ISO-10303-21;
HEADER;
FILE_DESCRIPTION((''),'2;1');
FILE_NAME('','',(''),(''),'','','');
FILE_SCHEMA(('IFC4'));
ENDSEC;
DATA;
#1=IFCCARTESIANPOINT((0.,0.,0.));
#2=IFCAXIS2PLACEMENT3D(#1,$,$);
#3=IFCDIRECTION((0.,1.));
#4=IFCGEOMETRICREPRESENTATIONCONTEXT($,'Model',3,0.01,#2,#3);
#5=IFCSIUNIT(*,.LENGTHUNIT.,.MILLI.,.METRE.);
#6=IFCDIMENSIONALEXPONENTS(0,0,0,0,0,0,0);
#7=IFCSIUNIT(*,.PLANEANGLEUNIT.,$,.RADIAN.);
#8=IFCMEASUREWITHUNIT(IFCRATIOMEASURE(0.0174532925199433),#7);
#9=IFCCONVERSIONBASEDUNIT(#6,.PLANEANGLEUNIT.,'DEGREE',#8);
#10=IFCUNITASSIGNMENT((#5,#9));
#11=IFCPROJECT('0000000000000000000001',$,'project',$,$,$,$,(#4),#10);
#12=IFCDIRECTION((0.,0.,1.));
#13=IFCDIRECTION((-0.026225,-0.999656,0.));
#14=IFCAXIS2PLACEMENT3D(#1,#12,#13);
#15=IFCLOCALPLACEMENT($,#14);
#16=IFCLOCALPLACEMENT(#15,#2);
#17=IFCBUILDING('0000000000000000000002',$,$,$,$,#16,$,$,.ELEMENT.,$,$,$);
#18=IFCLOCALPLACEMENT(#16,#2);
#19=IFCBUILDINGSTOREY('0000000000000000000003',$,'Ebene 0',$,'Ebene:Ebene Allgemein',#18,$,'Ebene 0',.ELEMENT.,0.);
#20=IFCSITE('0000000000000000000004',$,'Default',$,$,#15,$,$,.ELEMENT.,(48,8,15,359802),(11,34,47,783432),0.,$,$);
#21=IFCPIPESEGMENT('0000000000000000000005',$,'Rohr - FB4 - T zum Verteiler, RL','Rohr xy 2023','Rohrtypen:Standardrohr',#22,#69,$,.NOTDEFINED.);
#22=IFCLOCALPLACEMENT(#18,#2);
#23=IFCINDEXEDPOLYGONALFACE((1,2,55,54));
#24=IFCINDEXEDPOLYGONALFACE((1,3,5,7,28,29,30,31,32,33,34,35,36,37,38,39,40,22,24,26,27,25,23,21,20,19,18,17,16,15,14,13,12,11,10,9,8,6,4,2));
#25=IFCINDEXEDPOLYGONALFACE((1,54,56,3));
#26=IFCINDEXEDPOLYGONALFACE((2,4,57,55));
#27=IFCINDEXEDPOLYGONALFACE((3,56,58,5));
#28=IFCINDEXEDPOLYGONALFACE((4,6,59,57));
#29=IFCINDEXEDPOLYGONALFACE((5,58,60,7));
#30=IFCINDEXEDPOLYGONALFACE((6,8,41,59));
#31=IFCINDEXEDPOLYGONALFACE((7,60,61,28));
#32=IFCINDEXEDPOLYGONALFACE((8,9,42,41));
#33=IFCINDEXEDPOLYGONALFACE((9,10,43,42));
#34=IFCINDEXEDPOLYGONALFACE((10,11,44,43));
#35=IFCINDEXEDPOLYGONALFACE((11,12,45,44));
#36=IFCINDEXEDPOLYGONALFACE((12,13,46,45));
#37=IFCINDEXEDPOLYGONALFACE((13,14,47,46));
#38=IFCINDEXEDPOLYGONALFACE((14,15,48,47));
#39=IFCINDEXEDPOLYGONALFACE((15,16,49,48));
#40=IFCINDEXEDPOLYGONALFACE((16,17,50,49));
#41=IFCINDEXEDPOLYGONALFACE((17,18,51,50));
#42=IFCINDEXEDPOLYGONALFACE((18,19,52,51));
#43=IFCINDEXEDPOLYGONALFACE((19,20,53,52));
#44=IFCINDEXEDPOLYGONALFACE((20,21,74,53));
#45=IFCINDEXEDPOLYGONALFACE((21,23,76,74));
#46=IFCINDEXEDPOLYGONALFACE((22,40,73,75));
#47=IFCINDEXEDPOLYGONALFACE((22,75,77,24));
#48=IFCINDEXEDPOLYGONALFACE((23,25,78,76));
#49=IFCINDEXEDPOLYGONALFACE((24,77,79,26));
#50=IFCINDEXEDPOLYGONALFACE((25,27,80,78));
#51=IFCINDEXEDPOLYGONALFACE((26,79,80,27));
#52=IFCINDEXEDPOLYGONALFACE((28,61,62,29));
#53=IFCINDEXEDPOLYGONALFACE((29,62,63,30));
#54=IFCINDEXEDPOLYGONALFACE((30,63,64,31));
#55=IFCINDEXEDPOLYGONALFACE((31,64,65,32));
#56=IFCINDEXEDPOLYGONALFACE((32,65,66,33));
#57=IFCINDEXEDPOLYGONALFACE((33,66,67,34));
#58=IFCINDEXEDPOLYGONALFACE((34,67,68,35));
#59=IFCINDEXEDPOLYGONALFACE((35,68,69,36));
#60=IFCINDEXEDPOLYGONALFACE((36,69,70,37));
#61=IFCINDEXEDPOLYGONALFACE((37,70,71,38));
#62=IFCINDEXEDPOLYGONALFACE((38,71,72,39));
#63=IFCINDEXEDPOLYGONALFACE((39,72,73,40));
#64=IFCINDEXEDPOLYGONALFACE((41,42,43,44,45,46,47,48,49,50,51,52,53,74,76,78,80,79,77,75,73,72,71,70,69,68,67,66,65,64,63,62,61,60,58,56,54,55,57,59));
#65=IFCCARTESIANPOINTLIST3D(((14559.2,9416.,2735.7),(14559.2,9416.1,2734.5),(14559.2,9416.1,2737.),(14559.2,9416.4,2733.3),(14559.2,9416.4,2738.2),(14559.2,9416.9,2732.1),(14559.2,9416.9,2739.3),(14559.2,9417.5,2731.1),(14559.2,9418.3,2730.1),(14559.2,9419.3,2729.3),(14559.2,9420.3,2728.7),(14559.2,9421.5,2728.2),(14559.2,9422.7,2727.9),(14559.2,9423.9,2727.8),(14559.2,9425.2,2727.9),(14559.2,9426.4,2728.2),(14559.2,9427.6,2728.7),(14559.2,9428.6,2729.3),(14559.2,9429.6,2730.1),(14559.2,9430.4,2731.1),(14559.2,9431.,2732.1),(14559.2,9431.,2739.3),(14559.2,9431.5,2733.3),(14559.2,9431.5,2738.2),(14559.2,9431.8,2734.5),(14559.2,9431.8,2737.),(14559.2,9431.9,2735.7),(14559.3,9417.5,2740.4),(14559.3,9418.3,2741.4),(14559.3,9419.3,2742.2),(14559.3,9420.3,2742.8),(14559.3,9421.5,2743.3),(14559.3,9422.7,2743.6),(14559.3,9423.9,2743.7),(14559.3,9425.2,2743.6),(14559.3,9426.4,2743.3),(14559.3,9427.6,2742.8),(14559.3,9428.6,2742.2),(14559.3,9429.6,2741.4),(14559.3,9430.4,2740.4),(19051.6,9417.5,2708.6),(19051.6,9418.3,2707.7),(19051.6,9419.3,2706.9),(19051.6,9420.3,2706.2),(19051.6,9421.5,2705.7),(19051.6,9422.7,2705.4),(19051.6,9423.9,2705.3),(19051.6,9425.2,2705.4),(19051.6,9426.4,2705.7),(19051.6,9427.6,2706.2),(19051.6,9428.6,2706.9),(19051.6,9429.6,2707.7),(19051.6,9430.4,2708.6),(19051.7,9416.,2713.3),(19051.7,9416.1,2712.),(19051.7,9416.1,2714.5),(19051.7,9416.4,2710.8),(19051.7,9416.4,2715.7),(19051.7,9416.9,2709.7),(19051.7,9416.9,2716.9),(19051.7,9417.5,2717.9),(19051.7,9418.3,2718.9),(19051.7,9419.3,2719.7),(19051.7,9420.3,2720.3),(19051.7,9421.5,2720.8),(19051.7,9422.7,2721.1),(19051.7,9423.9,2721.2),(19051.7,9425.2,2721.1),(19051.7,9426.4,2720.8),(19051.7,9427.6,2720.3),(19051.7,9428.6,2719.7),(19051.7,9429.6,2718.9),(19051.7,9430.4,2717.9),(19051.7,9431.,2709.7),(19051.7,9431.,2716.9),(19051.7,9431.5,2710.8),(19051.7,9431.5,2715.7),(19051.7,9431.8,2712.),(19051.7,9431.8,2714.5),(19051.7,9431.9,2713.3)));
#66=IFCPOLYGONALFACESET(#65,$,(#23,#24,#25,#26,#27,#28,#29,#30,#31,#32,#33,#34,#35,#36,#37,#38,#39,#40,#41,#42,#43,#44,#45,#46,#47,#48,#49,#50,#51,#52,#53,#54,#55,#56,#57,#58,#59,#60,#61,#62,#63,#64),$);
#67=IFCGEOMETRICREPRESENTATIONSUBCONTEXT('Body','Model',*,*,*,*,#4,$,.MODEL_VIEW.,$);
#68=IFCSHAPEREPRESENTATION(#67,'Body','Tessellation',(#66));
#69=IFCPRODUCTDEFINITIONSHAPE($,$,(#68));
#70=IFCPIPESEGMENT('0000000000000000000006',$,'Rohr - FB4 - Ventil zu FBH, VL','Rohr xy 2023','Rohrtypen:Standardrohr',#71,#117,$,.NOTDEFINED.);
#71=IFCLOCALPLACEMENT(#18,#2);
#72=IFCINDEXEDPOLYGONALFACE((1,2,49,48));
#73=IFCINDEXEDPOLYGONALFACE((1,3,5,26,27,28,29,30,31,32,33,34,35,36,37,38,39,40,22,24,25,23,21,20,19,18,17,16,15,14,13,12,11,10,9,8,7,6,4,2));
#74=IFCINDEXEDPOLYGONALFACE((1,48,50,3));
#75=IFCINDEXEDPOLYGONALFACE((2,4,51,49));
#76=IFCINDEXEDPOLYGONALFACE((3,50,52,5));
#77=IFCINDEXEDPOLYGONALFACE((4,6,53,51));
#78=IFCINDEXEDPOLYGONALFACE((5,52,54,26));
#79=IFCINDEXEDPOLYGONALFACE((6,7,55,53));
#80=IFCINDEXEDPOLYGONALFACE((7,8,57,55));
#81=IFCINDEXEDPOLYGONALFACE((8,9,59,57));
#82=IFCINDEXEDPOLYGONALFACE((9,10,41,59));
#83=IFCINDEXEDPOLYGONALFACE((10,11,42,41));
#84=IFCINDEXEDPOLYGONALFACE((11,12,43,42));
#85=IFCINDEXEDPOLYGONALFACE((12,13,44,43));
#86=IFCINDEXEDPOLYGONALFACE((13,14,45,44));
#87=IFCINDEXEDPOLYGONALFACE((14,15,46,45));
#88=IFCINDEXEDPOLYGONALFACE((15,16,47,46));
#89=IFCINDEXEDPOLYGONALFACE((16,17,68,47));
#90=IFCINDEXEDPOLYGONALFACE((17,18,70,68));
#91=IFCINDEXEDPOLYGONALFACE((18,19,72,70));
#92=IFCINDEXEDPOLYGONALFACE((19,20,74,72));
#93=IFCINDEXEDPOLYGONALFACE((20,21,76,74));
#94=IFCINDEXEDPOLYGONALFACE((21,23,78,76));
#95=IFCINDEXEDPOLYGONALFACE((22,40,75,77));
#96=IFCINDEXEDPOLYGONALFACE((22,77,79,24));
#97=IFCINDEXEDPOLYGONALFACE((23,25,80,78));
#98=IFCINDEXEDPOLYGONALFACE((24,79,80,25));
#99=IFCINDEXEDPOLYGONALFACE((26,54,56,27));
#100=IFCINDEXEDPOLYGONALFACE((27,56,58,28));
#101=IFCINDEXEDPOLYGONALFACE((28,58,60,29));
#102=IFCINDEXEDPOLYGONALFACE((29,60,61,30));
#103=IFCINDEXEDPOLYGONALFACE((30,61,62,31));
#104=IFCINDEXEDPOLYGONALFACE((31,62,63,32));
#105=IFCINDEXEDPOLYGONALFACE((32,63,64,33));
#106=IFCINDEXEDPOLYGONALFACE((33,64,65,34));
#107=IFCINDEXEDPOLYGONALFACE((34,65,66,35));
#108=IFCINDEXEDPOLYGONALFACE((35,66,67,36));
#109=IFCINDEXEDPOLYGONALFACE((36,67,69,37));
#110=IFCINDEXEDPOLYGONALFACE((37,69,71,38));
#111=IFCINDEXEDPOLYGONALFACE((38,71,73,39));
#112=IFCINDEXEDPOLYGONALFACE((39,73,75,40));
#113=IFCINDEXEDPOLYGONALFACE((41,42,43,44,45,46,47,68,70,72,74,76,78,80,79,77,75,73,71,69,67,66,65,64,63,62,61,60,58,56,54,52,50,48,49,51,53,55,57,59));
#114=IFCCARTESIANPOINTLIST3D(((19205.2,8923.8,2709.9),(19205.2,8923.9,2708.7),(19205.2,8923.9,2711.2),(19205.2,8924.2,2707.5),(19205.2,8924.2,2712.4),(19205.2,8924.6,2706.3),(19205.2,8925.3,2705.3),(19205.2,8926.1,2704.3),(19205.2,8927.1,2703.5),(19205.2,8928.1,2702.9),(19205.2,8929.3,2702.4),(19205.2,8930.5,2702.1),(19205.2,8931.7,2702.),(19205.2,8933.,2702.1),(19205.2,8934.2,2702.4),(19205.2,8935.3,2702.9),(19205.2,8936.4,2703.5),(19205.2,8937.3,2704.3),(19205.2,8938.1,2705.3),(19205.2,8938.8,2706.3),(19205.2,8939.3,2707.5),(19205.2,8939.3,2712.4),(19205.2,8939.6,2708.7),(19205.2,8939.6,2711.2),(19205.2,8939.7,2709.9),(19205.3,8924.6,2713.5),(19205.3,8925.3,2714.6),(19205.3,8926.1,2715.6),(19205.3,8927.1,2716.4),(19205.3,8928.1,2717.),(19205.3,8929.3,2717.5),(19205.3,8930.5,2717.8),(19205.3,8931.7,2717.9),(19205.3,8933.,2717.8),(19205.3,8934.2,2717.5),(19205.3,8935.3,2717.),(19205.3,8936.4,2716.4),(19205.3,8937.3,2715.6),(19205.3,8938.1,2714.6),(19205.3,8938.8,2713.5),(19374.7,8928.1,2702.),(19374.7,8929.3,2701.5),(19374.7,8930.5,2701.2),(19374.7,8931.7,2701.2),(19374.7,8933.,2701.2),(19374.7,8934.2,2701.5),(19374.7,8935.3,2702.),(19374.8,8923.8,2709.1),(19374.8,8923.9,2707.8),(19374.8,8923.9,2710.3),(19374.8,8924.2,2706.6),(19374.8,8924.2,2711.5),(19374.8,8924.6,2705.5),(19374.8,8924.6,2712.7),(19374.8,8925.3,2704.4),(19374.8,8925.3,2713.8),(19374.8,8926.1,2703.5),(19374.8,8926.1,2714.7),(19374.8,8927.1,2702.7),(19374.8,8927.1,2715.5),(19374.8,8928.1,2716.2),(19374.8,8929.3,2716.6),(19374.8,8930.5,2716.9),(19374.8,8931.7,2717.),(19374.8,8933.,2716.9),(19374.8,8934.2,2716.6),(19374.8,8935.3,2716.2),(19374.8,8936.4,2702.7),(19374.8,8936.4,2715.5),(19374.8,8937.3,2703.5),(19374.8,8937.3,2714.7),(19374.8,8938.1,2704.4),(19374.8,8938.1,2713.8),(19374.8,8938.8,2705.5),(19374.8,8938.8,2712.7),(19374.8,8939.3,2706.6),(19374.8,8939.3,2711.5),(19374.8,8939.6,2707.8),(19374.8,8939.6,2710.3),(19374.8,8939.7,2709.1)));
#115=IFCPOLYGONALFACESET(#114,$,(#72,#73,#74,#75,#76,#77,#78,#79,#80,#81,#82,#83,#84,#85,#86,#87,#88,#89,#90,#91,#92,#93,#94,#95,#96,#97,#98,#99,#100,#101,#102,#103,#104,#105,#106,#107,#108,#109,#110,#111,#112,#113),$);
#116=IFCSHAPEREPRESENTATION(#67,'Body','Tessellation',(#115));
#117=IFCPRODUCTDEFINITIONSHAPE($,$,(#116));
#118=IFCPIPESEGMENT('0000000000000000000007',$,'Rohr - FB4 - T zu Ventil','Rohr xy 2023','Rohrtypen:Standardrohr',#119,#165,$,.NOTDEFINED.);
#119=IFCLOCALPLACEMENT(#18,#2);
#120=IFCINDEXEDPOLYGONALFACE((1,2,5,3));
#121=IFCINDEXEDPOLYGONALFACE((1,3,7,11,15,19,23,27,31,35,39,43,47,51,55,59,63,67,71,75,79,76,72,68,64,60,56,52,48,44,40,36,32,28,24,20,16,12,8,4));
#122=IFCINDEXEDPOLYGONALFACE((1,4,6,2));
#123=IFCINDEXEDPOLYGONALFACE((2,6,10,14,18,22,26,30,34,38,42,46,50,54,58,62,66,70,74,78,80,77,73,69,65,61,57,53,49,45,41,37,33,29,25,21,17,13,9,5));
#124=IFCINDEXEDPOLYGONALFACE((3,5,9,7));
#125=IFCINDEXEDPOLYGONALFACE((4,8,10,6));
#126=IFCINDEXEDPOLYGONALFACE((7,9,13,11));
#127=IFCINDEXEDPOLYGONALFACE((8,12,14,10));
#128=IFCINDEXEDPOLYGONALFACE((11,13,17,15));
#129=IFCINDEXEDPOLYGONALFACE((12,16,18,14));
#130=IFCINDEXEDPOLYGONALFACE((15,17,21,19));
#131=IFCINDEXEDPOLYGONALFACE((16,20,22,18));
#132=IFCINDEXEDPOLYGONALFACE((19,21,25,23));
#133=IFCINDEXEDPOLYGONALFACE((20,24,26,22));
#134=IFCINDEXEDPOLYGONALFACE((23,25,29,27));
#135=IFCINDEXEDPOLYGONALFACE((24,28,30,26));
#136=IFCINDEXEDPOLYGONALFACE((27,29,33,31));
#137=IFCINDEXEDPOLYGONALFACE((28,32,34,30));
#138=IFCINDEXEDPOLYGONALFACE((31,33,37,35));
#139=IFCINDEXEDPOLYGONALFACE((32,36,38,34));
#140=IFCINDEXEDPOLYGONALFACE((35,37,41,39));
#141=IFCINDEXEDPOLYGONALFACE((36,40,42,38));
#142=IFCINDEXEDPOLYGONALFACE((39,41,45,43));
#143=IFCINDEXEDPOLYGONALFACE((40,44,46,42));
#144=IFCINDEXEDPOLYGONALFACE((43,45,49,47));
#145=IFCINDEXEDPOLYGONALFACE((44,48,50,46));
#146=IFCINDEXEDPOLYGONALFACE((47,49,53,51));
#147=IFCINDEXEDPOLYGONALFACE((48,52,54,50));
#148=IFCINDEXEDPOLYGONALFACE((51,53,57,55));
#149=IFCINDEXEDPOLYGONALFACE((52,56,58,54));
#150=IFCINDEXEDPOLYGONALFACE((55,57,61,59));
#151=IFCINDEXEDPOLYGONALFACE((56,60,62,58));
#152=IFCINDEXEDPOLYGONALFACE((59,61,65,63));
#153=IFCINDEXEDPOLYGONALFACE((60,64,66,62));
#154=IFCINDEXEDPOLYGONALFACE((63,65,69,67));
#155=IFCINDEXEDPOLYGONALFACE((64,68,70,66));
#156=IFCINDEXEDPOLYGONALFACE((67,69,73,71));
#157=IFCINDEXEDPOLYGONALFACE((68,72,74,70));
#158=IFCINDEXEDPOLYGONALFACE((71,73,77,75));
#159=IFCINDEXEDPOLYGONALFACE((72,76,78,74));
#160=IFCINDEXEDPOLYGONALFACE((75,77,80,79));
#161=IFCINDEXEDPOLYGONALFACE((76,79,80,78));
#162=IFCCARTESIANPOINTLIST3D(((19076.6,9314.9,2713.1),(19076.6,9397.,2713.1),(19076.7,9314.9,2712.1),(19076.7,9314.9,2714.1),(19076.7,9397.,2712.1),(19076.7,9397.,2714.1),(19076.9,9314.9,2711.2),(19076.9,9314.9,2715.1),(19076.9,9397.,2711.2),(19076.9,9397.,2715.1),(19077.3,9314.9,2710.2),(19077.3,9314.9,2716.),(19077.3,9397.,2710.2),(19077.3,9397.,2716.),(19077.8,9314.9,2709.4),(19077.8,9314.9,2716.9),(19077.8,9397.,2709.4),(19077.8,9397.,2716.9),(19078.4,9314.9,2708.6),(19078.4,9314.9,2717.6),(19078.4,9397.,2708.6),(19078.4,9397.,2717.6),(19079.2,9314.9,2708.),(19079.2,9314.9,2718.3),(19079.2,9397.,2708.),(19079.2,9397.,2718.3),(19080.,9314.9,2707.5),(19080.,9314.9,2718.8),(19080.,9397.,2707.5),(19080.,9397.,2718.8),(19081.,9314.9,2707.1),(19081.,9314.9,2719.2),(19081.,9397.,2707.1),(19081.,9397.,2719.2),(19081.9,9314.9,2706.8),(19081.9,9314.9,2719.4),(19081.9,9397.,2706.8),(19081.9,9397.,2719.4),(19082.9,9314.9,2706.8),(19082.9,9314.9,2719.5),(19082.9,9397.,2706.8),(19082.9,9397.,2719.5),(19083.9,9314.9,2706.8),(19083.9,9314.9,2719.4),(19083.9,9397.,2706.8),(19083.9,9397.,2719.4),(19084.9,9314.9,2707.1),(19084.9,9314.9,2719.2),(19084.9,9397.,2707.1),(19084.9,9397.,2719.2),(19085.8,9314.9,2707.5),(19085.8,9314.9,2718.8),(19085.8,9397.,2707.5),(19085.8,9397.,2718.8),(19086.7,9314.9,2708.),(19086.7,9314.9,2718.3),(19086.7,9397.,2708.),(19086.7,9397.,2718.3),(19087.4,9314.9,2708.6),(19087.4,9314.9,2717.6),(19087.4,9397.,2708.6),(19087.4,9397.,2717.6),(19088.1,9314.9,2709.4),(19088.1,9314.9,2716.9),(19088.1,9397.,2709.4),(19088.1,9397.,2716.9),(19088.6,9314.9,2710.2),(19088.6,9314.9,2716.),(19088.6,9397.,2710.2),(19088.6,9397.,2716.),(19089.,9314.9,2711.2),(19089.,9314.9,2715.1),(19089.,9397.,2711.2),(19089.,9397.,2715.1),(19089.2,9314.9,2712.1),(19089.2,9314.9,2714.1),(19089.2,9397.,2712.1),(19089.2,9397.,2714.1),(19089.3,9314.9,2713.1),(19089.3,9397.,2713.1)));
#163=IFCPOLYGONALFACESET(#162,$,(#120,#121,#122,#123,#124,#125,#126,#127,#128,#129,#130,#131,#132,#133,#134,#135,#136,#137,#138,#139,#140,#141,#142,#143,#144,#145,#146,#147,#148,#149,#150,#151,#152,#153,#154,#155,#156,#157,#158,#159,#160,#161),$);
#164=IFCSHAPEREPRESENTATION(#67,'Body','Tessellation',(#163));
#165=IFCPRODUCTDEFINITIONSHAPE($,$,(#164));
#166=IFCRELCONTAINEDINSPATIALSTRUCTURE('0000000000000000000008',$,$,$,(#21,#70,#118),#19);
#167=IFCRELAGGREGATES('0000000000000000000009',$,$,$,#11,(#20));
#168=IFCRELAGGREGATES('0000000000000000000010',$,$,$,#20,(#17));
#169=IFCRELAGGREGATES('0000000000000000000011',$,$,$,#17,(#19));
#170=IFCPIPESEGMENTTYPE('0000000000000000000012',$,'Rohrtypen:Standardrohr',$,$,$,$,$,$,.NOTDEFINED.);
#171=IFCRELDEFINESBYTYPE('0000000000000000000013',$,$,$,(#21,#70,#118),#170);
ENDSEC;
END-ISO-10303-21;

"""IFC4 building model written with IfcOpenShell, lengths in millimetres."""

from ifc_helpers import new_model, entity, si_unit, converted_unit, direction, frame, origin, place, context, subcontext, project, spatial, indexed_curve, outline, extrude, type_object, element, save


model = new_model("IFC4")

# Units and contexts
model_context = context("Model", 3, precision=0.01, world=origin(), true_north=direction((0.0, 1.0)))
body_context = subcontext(model_context, "Body", "Model", "MODEL_VIEW")
ifc_project = project(units=[si_unit("LENGTHUNIT", "METRE", prefix="MILLI"), converted_unit("PLANEANGLEUNIT", "DEGREE", entity("IfcRatioMeasure", 0.0174532925199433), si_unit("PLANEANGLEUNIT", "RADIAN"), dimensions=[0, 0, 0, 0, 0, 0, 0])], contexts=[model_context])

# Site, building, storey
site_placement = place(None, frame((0.0, 0.0, 0.0), z_axis=(0.0, 0.0, 1.0), x_axis=(-0.026225, -0.999656, 0.0)))
site = spatial("IfcSite", under=ifc_project, at=site_placement, Name="Default", CompositionType="ELEMENT", RefLatitude=(48, 8, 15, 359802), RefLongitude=(11, 34, 47, 783432), RefElevation=0.0)
building_placement = place(site_placement, origin())
building = spatial("IfcBuilding", under=site, at=building_placement, CompositionType="ELEMENT")
storey_placement = place(building_placement, origin())
storey = spatial("IfcBuildingStorey", under=building, at=storey_placement, Name="Ebene 0", ObjectType="Ebene:Ebene Allgemein", LongName="Ebene 0", CompositionType="ELEMENT", Elevation=0.0)

# Pipe segments
pipe_segment_type = type_object("IfcPipeSegmentType", Name="Rohrtypen:Standardrohr", PredefinedType="NOTDEFINED")
pipe_segment_1_placement = place(storey_placement, origin())
element("IfcPipeSegment", 1, at=pipe_segment_1_placement, inside=storey, type_object=pipe_segment_type, Name="Rohr - FB4 - T zum Verteiler, RL", Description="Rohr xy 2023", ObjectType="Rohrtypen:Standardrohr", PredefinedType="NOTDEFINED", context=body_context, shape_type="SweptSolid", body=[
    extrude(outline(indexed_curve([(7.9, 0.0), (7.8, 1.2), (7.6, 2.5), (7.1, 3.6), (6.4, 4.7), (5.6, 5.6), (4.7, 6.4), (3.6, 7.1), (2.5, 7.6), (1.2, 7.8), (0.0, 7.9), (-1.2, 7.8), (-2.5, 7.6), (-3.6, 7.1), (-4.7, 6.4), (-5.6, 5.6), (-6.4, 4.7), (-7.1, 3.6), (-7.6, 2.5), (-7.8, 1.2), (-7.9, 0.0), (-7.8, -1.2), (-7.6, -2.5), (-7.1, -3.6), (-6.4, -4.7), (-5.6, -5.6), (-4.7, -6.4), (-3.6, -7.1), (-2.5, -7.6), (-1.2, -7.8), (0.0, -7.9), (1.2, -7.8), (2.5, -7.6), (3.6, -7.1), (4.7, -6.4), (5.6, -5.6), (6.4, -4.7), (7.1, -3.6), (7.6, -2.5), (7.8, -1.2), (7.9, 0.0)], self_intersect=False)), frame((14559.2, 9423.9, 2735.7), z_axis=(0.999988, 0.0, -0.005), x_axis=(0.0, 1.0, 0.0)), (0.0, 0.0, 1.0), 4492.5),
])
pipe_segment_2_placement = place(storey_placement, origin())
element("IfcPipeSegment", 2, at=pipe_segment_2_placement, inside=storey, type_object=pipe_segment_type, Name="Rohr - FB4 - Ventil zu FBH, VL", Description="Rohr xy 2023", ObjectType="Rohrtypen:Standardrohr", PredefinedType="NOTDEFINED", context=body_context, shape_type="SweptSolid", body=[
    extrude(outline(indexed_curve([(7.9, 0.0), (7.8, 1.2), (7.6, 2.5), (7.1, 3.6), (6.4, 4.7), (5.6, 5.6), (4.7, 6.4), (3.6, 7.1), (2.5, 7.6), (1.2, 7.8), (0.0, 7.9), (-1.2, 7.8), (-2.5, 7.6), (-3.6, 7.1), (-4.7, 6.4), (-5.6, 5.6), (-6.4, 4.7), (-7.1, 3.6), (-7.6, 2.5), (-7.8, 1.2), (-7.9, 0.0), (-7.8, -1.2), (-7.6, -2.5), (-7.1, -3.6), (-6.4, -4.7), (-5.6, -5.6), (-4.7, -6.4), (-3.6, -7.1), (-2.5, -7.6), (-1.2, -7.8), (0.0, -7.9), (1.2, -7.8), (2.5, -7.6), (3.6, -7.1), (4.7, -6.4), (5.6, -5.6), (6.4, -4.7), (7.1, -3.6), (7.6, -2.5), (7.8, -1.2), (7.9, 0.0)], self_intersect=False)), frame((19205.2, 8931.7, 2709.9), z_axis=(0.999988, 0.0, -0.005), x_axis=(0.0, 1.0, 0.0)), (0.0, 0.0, 1.0), 169.5),
])
pipe_segment_3_placement = place(storey_placement, origin())
element("IfcPipeSegment", 3, at=pipe_segment_3_placement, inside=storey, type_object=pipe_segment_type, Name="Rohr - FB4 - T zu Ventil", Description="Rohr xy 2023", ObjectType="Rohrtypen:Standardrohr", PredefinedType="NOTDEFINED", context=body_context, shape_type="SweptSolid", body=[
    extrude(outline(indexed_curve([(6.4, 0.0), (6.3, 1.0), (6.0, 2.0), (5.7, 2.9), (5.1, 3.7), (4.5, 4.5), (3.7, 5.1), (2.9, 5.7), (2.0, 6.0), (1.0, 6.3), (0.0, 6.4), (-1.0, 6.3), (-2.0, 6.0), (-2.9, 5.7), (-3.7, 5.1), (-4.5, 4.5), (-5.1, 3.7), (-5.7, 2.9), (-6.0, 2.0), (-6.3, 1.0), (-6.4, 0.0), (-6.3, -1.0), (-6.0, -2.0), (-5.7, -2.9), (-5.1, -3.7), (-4.5, -4.5), (-3.7, -5.1), (-2.9, -5.7), (-2.0, -6.0), (-1.0, -6.3), (0.0, -6.4), (1.0, -6.3), (2.0, -6.0), (2.9, -5.7), (3.7, -5.1), (4.5, -4.5), (5.1, -3.7), (5.7, -2.9), (6.0, -2.0), (6.3, -1.0), (6.4, 0.0)], self_intersect=False)), frame((19082.9, 9314.9, 2713.1), z_axis=(0.0, 1.0, 0.0), x_axis=(-1.0, 0.0, 0.0)), (0.0, 0.0, 1.0), 82.2),
])

save(model, "model.ifc")
